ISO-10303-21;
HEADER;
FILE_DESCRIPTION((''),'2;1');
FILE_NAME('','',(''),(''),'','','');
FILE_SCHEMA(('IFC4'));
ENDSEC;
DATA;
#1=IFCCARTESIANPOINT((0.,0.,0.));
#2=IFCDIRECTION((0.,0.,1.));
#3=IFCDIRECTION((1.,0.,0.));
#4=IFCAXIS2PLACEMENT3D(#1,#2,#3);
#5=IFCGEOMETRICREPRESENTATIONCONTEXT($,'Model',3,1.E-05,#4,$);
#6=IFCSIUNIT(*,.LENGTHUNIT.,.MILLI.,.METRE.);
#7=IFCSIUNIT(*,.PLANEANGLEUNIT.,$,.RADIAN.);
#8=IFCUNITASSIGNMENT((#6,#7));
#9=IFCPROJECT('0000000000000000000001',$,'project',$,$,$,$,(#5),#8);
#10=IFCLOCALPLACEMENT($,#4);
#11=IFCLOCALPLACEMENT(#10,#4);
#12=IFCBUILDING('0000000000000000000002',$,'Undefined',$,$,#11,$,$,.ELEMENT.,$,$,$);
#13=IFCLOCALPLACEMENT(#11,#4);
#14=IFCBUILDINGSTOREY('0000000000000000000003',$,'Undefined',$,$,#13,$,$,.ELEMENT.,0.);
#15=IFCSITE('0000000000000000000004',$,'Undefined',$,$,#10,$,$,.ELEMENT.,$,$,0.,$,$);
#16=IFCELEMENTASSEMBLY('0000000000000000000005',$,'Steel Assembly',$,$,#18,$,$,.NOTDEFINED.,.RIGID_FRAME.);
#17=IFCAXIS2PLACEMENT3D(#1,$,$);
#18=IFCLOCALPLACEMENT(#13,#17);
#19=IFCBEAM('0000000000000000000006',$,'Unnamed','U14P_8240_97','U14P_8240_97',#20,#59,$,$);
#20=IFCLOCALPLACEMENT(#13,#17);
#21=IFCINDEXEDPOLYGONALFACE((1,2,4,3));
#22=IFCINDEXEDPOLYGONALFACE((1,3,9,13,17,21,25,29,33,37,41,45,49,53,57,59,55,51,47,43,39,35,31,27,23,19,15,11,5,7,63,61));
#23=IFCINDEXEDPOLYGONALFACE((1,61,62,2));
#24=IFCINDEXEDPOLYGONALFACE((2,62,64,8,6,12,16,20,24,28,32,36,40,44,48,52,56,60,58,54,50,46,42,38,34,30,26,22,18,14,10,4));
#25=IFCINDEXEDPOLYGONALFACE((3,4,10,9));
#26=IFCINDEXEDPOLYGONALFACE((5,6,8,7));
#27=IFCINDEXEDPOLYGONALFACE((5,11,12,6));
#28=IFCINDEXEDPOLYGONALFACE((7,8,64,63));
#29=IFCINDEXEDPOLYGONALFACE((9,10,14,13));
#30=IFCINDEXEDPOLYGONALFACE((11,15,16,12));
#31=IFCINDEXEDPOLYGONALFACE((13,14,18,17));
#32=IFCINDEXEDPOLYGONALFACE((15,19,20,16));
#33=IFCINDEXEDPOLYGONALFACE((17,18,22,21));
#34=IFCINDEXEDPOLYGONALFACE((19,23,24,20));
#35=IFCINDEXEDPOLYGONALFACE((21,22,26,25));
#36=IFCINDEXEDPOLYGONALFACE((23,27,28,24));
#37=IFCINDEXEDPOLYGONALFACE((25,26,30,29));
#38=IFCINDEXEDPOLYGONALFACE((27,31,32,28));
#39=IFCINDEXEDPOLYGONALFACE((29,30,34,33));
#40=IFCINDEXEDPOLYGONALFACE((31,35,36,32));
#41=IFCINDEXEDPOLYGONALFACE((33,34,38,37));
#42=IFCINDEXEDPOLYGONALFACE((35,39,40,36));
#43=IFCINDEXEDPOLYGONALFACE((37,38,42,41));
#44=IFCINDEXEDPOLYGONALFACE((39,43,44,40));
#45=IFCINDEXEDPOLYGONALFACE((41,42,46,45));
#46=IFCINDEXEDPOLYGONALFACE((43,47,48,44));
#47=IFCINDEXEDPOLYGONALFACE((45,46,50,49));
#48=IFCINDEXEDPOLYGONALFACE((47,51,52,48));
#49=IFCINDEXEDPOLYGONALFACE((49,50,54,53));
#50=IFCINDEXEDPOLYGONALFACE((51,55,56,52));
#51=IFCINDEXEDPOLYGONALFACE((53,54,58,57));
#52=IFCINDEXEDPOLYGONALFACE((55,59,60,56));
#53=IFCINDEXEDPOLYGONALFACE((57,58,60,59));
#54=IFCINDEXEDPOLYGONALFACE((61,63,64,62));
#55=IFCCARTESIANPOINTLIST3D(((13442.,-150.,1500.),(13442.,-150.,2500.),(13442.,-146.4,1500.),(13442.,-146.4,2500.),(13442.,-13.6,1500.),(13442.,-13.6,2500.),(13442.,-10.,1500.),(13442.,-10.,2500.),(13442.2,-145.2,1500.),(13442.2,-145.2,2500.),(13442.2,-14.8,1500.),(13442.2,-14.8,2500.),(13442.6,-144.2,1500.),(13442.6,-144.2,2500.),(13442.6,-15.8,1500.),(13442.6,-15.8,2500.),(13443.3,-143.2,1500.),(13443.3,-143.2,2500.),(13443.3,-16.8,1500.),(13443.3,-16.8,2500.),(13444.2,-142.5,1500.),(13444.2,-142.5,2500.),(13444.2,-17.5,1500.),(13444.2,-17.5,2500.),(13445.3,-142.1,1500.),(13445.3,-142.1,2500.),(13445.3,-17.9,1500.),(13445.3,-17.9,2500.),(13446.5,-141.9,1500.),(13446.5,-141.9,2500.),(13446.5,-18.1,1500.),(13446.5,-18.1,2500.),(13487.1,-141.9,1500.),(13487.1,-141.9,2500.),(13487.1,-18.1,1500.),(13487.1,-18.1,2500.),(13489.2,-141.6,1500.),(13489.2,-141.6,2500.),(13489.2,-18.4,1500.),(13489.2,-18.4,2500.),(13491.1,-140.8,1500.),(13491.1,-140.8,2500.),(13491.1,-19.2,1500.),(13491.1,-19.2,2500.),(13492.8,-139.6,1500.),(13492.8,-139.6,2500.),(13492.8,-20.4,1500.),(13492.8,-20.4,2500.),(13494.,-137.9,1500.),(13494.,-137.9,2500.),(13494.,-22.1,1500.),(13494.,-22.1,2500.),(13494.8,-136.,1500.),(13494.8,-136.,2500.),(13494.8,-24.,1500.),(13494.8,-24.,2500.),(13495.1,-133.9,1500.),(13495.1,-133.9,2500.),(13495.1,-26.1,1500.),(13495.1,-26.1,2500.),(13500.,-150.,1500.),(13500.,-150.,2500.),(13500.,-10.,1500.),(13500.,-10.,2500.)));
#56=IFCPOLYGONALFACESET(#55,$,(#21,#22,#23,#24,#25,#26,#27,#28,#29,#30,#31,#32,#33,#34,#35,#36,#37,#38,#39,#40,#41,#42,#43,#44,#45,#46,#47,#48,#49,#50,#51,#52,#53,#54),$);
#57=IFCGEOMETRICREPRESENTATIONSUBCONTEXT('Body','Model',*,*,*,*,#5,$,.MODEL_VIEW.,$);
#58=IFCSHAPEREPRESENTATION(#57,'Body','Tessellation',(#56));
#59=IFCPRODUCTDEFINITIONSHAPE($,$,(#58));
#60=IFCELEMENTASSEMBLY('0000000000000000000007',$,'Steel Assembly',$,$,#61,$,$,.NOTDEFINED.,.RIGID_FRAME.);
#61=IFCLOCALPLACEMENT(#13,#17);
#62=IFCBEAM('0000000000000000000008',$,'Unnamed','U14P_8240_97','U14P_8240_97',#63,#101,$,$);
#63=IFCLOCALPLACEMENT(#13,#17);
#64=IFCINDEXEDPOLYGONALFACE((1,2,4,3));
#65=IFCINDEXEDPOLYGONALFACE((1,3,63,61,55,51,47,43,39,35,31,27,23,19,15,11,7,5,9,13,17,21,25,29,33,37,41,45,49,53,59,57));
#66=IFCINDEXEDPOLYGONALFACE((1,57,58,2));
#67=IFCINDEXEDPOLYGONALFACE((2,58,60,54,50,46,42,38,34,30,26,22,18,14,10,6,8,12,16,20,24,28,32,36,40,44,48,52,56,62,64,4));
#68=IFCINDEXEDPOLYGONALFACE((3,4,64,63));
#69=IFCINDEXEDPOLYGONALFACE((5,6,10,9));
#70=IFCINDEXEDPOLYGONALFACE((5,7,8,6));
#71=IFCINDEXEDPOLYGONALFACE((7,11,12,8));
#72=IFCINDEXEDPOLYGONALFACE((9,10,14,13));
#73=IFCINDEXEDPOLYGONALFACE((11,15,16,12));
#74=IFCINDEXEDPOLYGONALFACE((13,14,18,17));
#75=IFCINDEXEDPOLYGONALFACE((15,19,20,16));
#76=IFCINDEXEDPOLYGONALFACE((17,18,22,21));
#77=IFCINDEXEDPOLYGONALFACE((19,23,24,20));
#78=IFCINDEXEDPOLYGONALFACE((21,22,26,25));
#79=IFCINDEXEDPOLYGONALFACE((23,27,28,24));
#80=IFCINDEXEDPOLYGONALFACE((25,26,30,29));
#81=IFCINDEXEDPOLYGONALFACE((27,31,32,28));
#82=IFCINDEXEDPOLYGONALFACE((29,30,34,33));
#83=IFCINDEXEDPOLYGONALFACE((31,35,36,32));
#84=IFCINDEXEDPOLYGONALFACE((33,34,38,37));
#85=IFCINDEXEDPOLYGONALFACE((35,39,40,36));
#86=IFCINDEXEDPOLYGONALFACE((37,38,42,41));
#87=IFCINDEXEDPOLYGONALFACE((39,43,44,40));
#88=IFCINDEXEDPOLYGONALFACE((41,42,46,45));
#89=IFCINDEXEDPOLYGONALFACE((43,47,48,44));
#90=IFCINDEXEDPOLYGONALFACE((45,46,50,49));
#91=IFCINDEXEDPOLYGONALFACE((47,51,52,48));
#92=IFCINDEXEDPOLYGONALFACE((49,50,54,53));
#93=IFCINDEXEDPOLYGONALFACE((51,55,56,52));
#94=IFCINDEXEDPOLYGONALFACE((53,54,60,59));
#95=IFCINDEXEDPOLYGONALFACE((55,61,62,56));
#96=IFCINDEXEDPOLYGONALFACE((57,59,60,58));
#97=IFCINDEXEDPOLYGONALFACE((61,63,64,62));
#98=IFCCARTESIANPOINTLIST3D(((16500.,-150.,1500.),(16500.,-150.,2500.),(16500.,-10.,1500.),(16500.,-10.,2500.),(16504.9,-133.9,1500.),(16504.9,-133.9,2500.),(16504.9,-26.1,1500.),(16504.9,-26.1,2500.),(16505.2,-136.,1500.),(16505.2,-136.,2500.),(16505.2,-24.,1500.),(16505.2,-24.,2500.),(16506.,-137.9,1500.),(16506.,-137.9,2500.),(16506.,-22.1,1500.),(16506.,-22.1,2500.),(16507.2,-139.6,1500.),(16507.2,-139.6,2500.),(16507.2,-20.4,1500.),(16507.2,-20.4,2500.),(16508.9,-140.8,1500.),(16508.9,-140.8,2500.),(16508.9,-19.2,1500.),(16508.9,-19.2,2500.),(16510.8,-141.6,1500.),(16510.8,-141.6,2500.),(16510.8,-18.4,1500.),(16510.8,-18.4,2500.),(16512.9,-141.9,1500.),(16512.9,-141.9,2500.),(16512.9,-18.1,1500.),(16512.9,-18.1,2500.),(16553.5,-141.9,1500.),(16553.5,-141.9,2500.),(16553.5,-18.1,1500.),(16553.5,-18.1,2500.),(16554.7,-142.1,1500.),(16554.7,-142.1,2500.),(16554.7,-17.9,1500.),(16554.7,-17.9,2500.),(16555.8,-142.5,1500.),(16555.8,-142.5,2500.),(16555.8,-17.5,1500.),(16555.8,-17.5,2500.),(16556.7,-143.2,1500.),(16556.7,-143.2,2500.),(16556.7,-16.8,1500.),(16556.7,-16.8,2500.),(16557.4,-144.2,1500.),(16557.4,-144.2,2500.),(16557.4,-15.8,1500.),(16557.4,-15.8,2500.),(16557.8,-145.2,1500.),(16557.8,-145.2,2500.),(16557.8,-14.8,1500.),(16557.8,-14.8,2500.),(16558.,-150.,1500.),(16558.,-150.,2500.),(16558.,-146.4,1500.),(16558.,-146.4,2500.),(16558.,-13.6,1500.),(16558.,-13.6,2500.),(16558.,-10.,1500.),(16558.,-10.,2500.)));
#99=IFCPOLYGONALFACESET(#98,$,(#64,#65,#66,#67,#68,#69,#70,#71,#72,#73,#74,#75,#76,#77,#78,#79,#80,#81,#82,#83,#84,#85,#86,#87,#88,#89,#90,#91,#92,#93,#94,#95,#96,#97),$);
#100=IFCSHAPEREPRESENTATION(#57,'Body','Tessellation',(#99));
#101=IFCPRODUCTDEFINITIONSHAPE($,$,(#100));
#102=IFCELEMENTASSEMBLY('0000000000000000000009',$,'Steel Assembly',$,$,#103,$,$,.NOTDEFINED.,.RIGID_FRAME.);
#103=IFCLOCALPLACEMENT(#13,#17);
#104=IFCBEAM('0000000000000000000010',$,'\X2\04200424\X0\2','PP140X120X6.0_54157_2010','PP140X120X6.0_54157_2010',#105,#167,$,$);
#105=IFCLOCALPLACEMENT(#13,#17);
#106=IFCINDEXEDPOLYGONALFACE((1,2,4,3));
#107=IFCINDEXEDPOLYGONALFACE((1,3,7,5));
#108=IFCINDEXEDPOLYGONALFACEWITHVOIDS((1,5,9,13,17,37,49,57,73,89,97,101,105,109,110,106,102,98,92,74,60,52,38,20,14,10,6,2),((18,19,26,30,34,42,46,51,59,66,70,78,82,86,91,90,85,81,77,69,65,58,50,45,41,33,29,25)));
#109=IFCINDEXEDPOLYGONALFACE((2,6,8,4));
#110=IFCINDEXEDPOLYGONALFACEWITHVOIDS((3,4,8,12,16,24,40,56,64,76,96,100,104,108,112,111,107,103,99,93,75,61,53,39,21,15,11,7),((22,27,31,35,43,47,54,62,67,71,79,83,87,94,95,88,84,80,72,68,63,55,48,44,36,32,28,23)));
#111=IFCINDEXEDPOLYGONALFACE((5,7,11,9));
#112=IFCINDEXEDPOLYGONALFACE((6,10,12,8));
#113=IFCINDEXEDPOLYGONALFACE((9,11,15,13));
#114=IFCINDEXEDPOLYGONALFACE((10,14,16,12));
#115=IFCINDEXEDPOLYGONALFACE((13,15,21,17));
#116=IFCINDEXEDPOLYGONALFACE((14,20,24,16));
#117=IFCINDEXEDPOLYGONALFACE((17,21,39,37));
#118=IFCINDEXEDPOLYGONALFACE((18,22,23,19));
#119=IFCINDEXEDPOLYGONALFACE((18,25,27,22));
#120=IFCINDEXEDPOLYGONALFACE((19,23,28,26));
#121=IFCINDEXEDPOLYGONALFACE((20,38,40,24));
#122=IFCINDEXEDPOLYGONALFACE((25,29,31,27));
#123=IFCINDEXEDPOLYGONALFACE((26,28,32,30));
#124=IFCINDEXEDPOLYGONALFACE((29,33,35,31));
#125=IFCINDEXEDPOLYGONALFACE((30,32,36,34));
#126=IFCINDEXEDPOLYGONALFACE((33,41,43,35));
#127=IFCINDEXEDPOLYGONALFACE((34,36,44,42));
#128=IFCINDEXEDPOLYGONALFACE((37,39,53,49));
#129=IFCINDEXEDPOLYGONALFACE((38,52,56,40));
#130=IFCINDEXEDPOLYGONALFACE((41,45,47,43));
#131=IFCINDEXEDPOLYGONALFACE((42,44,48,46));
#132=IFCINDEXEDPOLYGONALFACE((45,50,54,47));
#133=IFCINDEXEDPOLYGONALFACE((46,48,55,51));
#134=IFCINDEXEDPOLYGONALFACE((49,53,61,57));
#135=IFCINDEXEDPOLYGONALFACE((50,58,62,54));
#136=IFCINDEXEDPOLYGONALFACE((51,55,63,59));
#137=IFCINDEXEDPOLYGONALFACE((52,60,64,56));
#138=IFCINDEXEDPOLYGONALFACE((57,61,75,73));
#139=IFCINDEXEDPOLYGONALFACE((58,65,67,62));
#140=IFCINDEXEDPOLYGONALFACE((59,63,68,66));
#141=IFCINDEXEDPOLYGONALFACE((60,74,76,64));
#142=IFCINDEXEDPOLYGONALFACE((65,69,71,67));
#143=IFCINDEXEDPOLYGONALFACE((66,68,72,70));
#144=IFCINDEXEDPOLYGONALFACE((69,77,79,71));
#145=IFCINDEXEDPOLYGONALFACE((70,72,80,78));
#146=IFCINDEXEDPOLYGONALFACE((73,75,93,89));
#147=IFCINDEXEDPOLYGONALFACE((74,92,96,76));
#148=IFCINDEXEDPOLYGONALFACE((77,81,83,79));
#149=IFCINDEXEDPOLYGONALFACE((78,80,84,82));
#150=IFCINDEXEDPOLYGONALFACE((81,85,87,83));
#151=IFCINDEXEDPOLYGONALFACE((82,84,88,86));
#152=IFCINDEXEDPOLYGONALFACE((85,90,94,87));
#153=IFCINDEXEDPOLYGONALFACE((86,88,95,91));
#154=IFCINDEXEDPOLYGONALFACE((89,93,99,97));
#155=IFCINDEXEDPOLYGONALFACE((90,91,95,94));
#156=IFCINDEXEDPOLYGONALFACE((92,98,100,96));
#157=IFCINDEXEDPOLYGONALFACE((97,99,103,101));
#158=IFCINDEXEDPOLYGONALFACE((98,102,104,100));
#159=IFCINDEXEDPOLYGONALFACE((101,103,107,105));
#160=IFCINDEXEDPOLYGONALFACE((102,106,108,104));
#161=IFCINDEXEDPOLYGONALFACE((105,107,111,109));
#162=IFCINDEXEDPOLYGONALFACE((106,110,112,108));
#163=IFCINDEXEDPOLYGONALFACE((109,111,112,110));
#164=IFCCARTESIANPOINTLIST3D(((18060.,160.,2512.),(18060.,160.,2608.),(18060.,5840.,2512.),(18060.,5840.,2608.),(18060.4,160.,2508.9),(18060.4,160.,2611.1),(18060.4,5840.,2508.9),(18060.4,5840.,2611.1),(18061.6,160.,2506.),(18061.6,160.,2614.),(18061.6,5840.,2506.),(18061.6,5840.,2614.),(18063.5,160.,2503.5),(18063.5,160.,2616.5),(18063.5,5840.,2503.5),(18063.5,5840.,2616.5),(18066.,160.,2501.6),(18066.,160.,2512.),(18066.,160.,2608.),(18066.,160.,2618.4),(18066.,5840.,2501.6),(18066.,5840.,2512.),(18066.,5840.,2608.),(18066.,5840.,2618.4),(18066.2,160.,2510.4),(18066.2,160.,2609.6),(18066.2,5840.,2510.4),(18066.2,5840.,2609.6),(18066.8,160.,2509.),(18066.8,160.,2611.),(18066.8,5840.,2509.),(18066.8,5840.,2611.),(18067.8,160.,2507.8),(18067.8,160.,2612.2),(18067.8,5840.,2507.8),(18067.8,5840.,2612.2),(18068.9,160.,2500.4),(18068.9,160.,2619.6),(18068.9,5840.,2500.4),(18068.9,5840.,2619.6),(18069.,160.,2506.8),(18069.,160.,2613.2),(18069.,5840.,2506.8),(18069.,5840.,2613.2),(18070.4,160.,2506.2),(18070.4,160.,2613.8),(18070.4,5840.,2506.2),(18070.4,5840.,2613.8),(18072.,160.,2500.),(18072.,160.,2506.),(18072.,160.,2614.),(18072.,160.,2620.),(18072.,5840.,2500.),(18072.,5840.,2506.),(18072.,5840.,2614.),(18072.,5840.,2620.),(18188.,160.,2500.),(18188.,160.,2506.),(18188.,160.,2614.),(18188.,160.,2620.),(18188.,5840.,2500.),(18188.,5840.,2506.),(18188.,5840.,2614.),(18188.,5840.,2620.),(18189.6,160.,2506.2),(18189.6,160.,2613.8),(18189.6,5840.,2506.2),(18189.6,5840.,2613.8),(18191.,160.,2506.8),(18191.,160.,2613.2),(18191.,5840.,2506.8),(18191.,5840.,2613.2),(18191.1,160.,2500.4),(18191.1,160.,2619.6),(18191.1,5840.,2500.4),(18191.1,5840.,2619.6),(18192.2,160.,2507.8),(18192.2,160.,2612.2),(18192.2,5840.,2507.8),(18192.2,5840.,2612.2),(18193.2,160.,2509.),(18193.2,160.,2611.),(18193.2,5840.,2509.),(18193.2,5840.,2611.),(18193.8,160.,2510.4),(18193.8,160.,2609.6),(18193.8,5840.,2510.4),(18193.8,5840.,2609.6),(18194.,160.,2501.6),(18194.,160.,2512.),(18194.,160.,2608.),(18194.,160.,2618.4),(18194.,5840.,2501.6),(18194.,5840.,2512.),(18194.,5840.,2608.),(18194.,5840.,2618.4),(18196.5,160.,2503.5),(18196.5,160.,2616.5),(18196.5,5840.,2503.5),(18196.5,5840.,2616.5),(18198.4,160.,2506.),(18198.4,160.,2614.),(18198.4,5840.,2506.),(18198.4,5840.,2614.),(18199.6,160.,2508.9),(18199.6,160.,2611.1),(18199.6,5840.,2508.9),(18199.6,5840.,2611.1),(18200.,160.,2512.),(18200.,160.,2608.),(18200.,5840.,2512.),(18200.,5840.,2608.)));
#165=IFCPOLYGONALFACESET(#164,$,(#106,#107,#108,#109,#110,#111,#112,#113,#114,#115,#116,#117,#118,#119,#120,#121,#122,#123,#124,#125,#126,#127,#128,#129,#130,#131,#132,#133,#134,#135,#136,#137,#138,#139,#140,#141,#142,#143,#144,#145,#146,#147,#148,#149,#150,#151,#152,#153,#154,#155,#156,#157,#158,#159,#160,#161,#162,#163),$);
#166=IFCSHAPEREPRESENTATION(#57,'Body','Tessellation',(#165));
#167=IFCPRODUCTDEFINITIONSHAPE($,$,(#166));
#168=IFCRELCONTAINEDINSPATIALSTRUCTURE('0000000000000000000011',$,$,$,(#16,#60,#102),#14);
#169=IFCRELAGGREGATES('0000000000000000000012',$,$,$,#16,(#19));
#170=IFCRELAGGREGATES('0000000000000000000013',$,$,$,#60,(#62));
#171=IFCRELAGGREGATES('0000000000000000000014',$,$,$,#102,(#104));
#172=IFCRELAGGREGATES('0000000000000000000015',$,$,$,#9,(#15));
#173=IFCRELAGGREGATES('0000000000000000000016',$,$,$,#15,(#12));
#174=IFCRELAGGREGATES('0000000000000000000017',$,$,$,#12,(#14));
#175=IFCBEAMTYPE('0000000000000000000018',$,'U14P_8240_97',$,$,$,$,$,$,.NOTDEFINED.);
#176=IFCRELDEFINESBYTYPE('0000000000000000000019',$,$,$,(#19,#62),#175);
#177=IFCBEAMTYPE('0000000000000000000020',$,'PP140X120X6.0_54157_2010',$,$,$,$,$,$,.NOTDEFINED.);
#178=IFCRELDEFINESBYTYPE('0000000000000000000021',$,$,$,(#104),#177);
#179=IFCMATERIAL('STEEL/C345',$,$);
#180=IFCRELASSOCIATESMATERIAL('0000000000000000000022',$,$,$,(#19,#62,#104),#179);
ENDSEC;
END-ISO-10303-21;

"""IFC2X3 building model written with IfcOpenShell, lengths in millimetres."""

from ifc_helpers import new_model, si_unit, frame, origin_with_axes, origin_2d_with_axis, place, context, subcontext, project, spatial, hollow_rectangle, u_section, extrude, material, type_object, element, aggregate, save


model = new_model("IFC2X3")

# Units and contexts
model_context = context("Model", 3, precision=1e-05, world=origin_with_axes())
body_context = subcontext(model_context, "Body", "Model", "MODEL_VIEW")
ifc_project = project(units=[si_unit("LENGTHUNIT", "METRE", prefix="MILLI"), si_unit("PLANEANGLEUNIT", "RADIAN")], contexts=[model_context])

# Site, building, storey
site_placement = place(None, origin_with_axes())
site = spatial("IfcSite", under=ifc_project, at=site_placement, Name="Undefined", CompositionType="ELEMENT", RefElevation=0.0)
building_placement = place(site_placement, origin_with_axes())
building = spatial("IfcBuilding", under=site, at=building_placement, Name="Undefined", CompositionType="ELEMENT")
storey_placement = place(building_placement, origin_with_axes())
storey = spatial("IfcBuildingStorey", under=building, at=storey_placement, Name="Undefined", CompositionType="ELEMENT", Elevation=0.0)

# Shared definitions
ifc_material_1 = material(Name="STEEL/C345")

# Element assemblies, beams
beam_type_1 = type_object("IfcBeamType", Name="U14P_8240_97", PredefinedType="NOTDEFINED")
assembly_1_placement = place(storey_placement, origin_with_axes())
assembly_1 = element("IfcElementAssembly", 1, at=assembly_1_placement, inside=storey, Name="Steel Assembly", AssemblyPlace="NOTDEFINED", PredefinedType="RIGID_FRAME")
beam_1_placement = place(assembly_1_placement, frame((13471.0, -80.0, 2500.0), z_axis=(0.0, -1.0, 0.0), x_axis=(0.0, 0.0, -1.0)))
beam_1 = element("IfcBeam", 2, at=beam_1_placement, type_object=beam_type_1, material=ifc_material_1, Name="Unnamed", Description="U14P_8240_97", ObjectType="U14P_8240_97", context=body_context, shape_type="SweptSolid", body=[
    extrude(u_section(Depth=140.0, FlangeWidth=58.0, WebThickness=4.9, FlangeThickness=8.1, FilletRadius=8.0, EdgeRadius=4.5, at=origin_2d_with_axis()), frame((1000.0, 0.0, 0.0), z_axis=(-1.0, 0.0, 0.0), x_axis=(0.0, -1.0, 0.0)), (0.0, 0.0, 1.0), 1000.0),
])
aggregate(assembly_1, [beam_1])
assembly_2_placement = place(storey_placement, origin_with_axes())
assembly_2 = element("IfcElementAssembly", 3, at=assembly_2_placement, inside=storey, Name="Steel Assembly", AssemblyPlace="NOTDEFINED", PredefinedType="RIGID_FRAME")
beam_2_placement = place(assembly_2_placement, frame((16529.0, -80.0, 2500.0), z_axis=(0.0, 1.0, 0.0), x_axis=(0.0, 0.0, -1.0)))
beam_2 = element("IfcBeam", 4, at=beam_2_placement, type_object=beam_type_1, material=ifc_material_1, Name="Unnamed", Description="U14P_8240_97", ObjectType="U14P_8240_97", context=body_context, shape_type="SweptSolid", body=[
    extrude(u_section(Depth=140.0, FlangeWidth=58.0, WebThickness=4.9, FlangeThickness=8.1, FilletRadius=8.0, EdgeRadius=4.5, at=origin_2d_with_axis()), frame((1000.0, 0.0, 0.0), z_axis=(-1.0, 0.0, 0.0), x_axis=(0.0, -1.0, 0.0)), (0.0, 0.0, 1.0), 1000.0),
])
aggregate(assembly_2, [beam_2])
assembly_3_placement = place(storey_placement, origin_with_axes())
assembly_3 = element("IfcElementAssembly", 5, at=assembly_3_placement, inside=storey, Name="Steel Assembly", AssemblyPlace="NOTDEFINED", PredefinedType="RIGID_FRAME")
beam_type_2 = type_object("IfcBeamType", Name="PP140X120X6.0_54157_2010", PredefinedType="NOTDEFINED")
beam_3_placement = place(assembly_3_placement, frame((18130.0, 160.0, 2560.0), z_axis=(1.0, 0.0, 0.0), x_axis=(0.0, 1.0, 0.0)))
beam_3 = element("IfcBeam", 6, at=beam_3_placement, type_object=beam_type_2, material=ifc_material_1, Name="РФ2", Description="PP140X120X6.0_54157_2010", ObjectType="PP140X120X6.0_54157_2010", context=body_context, shape_type="SweptSolid", body=[
    extrude(hollow_rectangle(XDim=120.0, YDim=140.0, WallThickness=6.0, InnerFilletRadius=6.0, OuterFilletRadius=12.0, at=origin_2d_with_axis()), frame((5680.0, 0.0, 0.0), z_axis=(-1.0, 0.0, 0.0), x_axis=(0.0, -1.0, 0.0)), (0.0, 0.0, 1.0), 5680.0),
])
aggregate(assembly_3, [beam_3])

save(model, "model.ifc")
